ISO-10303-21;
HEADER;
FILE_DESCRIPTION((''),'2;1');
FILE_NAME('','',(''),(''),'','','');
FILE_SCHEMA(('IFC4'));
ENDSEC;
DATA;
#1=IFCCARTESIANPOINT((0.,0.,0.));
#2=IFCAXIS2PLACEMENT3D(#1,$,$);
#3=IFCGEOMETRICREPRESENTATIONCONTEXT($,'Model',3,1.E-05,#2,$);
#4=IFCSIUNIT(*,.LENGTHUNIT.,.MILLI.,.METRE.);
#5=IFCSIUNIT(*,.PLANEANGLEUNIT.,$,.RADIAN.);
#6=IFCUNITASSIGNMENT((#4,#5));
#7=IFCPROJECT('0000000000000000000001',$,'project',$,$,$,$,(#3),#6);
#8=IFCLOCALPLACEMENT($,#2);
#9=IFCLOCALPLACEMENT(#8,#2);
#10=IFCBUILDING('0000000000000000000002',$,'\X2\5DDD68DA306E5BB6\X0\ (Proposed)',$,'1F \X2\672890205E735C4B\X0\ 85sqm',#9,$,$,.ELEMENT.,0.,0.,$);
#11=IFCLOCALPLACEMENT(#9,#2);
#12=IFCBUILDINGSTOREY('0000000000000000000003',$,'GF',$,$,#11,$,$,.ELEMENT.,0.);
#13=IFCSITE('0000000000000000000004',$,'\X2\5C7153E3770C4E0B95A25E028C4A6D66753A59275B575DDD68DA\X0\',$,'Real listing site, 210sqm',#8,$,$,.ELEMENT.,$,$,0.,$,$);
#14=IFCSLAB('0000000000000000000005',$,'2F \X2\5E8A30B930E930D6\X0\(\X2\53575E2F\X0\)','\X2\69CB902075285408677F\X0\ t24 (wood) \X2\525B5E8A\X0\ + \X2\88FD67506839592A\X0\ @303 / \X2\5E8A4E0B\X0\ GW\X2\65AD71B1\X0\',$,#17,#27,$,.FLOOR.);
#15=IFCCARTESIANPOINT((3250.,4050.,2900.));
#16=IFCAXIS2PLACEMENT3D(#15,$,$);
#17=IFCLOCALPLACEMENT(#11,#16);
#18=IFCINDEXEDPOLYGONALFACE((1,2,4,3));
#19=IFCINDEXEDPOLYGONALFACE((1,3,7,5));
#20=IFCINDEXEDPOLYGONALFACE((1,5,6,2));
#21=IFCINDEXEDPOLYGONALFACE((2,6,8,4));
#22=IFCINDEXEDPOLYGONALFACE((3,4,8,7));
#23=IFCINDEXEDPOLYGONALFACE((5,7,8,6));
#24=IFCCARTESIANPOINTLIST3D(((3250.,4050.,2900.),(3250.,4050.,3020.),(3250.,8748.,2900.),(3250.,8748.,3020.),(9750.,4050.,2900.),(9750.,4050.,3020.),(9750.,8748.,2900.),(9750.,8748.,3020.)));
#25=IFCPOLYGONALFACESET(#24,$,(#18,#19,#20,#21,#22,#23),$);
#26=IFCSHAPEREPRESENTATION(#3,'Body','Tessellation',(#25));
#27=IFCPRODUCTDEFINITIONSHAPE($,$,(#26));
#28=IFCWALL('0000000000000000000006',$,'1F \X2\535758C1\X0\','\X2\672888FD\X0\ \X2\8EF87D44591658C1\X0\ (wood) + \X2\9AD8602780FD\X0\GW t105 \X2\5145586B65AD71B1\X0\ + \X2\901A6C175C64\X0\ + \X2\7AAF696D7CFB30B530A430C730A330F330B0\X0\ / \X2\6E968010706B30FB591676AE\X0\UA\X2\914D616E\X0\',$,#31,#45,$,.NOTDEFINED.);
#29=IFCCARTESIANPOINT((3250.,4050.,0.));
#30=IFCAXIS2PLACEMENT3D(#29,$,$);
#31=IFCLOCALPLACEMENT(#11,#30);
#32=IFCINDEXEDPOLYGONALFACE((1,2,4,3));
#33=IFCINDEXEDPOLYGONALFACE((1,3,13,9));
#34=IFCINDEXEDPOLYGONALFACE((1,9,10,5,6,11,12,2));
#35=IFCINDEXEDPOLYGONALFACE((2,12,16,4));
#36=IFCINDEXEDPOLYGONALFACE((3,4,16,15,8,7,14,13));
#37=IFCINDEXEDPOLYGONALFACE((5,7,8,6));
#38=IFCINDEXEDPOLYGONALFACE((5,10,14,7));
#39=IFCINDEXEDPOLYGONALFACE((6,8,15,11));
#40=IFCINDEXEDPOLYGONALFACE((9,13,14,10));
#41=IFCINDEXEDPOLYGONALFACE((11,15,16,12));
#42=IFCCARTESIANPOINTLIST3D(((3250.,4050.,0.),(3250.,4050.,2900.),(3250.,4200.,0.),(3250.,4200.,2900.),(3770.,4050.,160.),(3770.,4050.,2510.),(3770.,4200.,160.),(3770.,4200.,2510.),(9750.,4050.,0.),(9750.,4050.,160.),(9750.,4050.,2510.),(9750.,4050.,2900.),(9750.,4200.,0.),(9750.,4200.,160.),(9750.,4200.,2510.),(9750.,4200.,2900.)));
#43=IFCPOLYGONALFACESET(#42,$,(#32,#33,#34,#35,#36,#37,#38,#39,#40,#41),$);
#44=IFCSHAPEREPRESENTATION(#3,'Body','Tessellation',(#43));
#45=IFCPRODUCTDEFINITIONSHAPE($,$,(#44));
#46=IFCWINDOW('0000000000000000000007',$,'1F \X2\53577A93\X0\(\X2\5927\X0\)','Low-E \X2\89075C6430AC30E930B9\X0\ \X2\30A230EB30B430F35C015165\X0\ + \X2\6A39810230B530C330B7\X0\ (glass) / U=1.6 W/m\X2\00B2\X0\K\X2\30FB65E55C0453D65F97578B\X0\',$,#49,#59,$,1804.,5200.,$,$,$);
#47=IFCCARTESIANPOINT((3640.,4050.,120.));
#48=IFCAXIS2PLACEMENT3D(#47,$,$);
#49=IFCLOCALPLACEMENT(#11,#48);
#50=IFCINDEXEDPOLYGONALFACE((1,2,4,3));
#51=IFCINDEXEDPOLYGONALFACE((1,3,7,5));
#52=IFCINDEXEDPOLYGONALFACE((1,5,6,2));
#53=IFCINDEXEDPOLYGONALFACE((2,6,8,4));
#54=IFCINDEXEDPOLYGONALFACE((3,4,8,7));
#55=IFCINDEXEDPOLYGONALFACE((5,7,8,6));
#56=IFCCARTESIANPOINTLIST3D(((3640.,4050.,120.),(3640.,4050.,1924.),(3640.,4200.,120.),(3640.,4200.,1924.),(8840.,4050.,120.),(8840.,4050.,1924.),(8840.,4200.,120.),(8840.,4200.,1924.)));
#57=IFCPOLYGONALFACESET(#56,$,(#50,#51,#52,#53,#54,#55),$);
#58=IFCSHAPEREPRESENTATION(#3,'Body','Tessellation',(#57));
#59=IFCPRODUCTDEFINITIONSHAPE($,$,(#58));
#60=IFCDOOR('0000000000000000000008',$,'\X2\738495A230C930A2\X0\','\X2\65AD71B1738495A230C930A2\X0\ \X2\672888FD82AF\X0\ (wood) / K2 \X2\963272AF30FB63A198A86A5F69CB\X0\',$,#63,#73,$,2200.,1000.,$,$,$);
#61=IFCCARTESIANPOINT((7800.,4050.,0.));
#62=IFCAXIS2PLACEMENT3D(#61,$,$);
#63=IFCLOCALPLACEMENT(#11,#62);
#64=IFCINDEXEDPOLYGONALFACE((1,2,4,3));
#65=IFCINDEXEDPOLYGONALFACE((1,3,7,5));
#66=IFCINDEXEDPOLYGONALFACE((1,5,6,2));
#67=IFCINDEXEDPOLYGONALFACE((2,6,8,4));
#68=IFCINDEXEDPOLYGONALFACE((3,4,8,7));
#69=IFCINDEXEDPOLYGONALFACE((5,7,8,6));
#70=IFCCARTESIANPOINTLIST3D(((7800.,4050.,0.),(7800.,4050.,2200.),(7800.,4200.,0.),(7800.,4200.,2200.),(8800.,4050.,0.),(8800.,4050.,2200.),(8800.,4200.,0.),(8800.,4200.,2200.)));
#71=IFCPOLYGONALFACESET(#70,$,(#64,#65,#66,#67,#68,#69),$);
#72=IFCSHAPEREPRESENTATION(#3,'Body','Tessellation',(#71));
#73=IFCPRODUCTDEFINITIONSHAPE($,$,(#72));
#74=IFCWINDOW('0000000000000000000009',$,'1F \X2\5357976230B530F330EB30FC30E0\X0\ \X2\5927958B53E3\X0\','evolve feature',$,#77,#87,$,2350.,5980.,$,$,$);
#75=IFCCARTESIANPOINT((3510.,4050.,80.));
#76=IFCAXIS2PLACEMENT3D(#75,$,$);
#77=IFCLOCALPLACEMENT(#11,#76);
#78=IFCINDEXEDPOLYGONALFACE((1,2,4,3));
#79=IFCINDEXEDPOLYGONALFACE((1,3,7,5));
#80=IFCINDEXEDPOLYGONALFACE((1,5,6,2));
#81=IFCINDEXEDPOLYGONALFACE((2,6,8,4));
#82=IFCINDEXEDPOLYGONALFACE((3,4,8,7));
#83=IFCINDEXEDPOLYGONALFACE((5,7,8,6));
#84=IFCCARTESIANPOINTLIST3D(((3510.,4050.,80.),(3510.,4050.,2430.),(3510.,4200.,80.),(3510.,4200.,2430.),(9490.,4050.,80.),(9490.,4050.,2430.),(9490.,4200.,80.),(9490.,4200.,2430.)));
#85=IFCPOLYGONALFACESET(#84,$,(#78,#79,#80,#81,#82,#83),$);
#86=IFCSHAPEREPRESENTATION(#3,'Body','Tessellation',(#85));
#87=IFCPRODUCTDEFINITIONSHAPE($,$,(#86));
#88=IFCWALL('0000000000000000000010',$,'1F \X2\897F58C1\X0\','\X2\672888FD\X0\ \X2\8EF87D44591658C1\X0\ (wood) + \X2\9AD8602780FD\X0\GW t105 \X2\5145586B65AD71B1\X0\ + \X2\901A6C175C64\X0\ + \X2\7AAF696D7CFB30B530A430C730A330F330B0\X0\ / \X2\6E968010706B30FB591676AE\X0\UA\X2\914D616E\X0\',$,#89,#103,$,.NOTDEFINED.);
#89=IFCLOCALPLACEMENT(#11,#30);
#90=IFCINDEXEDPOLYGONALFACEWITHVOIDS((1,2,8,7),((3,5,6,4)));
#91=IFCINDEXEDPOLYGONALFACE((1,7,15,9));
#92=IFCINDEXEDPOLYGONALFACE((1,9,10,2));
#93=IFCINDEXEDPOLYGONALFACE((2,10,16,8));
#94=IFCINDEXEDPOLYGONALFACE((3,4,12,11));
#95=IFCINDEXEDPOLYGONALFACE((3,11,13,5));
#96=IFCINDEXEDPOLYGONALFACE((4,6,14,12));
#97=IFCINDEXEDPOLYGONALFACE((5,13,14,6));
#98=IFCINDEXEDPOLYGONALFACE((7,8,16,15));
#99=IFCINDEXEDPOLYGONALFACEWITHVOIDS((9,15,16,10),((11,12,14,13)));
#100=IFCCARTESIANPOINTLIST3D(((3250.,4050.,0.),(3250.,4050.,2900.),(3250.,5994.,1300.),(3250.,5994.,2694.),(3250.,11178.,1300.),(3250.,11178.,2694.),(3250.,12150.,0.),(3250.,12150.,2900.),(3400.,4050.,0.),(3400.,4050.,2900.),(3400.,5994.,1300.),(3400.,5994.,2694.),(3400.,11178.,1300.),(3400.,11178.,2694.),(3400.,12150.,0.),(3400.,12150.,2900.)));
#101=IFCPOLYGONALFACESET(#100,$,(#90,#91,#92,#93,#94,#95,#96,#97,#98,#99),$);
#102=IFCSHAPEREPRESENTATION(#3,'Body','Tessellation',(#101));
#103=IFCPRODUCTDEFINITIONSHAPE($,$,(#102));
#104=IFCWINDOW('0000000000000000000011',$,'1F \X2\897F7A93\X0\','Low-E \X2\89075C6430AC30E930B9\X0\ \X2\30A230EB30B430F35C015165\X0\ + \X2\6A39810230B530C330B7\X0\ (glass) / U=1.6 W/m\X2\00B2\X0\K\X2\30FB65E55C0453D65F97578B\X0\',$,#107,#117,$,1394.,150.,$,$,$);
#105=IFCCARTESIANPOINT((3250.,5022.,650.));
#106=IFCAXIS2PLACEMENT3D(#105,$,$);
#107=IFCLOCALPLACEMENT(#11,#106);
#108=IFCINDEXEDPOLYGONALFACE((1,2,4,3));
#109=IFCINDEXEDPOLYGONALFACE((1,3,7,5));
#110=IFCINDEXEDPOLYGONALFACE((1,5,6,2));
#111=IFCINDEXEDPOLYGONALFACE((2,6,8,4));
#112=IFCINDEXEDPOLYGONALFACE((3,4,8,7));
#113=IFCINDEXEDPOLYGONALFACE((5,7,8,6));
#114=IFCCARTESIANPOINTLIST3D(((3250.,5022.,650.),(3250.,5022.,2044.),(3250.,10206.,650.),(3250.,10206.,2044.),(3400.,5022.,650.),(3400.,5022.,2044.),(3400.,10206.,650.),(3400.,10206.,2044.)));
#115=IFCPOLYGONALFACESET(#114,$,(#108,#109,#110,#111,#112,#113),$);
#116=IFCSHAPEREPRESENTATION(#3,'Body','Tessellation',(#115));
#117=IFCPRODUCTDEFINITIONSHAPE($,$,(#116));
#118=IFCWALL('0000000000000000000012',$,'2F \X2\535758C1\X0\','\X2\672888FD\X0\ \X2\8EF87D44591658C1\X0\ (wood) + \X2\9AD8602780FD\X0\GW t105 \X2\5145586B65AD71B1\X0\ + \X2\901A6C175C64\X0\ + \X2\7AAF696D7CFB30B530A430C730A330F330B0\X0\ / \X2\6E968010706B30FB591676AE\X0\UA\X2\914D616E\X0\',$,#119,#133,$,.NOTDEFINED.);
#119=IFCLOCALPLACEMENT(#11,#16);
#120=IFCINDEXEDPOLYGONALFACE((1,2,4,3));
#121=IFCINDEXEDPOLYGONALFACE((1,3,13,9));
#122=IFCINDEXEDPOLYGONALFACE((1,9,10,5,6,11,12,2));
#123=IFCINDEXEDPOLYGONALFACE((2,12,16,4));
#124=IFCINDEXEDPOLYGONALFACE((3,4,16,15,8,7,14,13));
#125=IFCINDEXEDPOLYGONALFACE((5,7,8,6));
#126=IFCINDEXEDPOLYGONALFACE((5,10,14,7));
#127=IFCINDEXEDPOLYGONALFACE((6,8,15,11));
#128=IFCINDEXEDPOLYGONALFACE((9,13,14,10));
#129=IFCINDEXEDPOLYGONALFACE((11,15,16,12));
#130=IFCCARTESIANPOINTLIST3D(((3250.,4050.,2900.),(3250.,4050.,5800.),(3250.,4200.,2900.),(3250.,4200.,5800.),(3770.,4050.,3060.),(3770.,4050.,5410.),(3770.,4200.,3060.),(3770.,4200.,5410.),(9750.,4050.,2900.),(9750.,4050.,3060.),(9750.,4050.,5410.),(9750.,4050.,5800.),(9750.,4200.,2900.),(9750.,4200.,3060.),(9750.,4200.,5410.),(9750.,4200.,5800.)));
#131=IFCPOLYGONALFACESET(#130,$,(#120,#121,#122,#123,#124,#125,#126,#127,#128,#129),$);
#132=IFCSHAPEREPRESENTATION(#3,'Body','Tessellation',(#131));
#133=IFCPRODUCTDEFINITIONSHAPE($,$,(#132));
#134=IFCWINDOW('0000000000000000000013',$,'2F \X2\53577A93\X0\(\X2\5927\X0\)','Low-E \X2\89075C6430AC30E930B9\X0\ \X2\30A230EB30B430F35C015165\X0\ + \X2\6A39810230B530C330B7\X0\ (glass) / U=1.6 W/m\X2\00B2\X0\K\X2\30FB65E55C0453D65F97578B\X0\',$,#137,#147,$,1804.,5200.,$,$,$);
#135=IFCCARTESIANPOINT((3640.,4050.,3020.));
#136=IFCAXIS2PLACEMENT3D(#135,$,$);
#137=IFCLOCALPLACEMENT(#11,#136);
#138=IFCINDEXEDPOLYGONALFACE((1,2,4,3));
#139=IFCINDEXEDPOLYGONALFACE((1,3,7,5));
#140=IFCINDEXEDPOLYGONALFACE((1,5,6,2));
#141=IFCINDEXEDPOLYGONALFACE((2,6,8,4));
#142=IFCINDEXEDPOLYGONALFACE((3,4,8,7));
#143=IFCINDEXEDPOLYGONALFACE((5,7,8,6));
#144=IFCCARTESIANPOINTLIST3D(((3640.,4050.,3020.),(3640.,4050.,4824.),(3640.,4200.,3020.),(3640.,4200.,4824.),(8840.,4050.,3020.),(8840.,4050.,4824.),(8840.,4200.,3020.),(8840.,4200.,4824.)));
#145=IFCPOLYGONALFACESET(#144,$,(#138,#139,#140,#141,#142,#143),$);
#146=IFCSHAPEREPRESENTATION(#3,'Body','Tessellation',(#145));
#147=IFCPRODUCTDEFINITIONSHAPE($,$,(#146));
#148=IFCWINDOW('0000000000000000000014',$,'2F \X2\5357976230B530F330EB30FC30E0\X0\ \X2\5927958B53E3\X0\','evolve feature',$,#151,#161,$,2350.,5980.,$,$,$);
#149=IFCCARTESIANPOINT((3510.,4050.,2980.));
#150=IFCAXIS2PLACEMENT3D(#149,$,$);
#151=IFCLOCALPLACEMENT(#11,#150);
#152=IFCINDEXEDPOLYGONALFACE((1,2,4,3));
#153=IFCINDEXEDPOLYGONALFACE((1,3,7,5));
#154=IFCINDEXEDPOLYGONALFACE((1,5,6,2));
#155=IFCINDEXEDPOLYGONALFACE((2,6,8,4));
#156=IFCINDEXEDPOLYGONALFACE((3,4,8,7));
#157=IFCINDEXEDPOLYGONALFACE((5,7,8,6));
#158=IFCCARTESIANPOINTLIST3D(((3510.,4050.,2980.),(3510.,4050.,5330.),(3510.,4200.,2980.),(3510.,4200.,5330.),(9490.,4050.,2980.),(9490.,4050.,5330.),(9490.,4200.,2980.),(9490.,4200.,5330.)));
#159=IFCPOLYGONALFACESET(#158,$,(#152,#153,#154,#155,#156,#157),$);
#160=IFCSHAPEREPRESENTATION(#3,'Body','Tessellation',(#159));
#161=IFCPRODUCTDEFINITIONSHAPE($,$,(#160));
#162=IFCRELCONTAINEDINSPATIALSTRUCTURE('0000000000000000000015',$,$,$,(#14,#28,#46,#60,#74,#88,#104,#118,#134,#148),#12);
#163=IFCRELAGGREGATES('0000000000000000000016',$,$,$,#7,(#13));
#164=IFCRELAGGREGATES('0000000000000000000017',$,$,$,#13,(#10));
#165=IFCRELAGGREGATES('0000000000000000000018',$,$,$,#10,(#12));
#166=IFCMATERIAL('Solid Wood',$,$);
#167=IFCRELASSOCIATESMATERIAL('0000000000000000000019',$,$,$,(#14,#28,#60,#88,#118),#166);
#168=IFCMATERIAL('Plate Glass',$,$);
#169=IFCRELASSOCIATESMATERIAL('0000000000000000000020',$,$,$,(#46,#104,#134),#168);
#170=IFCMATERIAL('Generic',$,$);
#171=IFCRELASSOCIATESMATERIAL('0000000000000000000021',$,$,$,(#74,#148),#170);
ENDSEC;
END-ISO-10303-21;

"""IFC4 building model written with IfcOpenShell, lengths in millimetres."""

from ifc_helpers import new_model, si_unit, frame, frame_2d, origin, place, context, project, spatial, rectangle, extrude, material, element, fill, save


model = new_model("IFC4")

# Units and contexts
model_context = context("Model", 3, precision=1e-05, world=origin())
ifc_project = project(units=[si_unit("LENGTHUNIT", "METRE", prefix="MILLI"), si_unit("PLANEANGLEUNIT", "RADIAN")], contexts=[model_context])

# Site, building, storey
site_placement = place(None, origin())
site = spatial("IfcSite", under=ifc_project, at=site_placement, Name="山口県下関市豊浦町大字川棚", ObjectType="Real listing site, 210sqm", CompositionType="ELEMENT", RefElevation=0.0)
building_placement = place(site_placement, origin())
building = spatial("IfcBuilding", under=site, at=building_placement, Name="川棚の家 (Proposed)", ObjectType="1F 木造平屋 85sqm", CompositionType="ELEMENT", ElevationOfRefHeight=0.0, ElevationOfTerrain=0.0)
storey_placement = place(building_placement, origin())
storey = spatial("IfcBuildingStorey", under=building, at=storey_placement, Name="GF", CompositionType="ELEMENT", Elevation=0.0)

# Slab
ifc_material_1 = material(Name="Solid Wood")
slab_1_placement = place(storey_placement, frame((3250.0, 4050.0, 2900.0)))
element("IfcSlab", 1, at=slab_1_placement, inside=storey, material=ifc_material_1, Name="2F 床スラブ(南帯)", Description="構造用合板 t24 (wood) 剛床 + 製材根太 @303 / 床下 GW断熱", PredefinedType="FLOOR", context=model_context, shape_type="SweptSolid", body=[
    extrude(rectangle(XDim=6500.0, YDim=4698.0, at=frame_2d((3250.0, 2349.0))), frame((3250.0, 4050.0, 2900.0)), (0.0, 0.0, 1.0), 120.0),
])
ifc_material_2 = material(Name="Generic")

# Wall, openings, windows, door
wall_1_placement = place(storey_placement, frame((3250.0, 4050.0, 0.0)))
wall_1 = element("IfcWall", 2, at=wall_1_placement, inside=storey, material=ifc_material_1, Name="1F 南壁", Description="木製 軸組外壁 (wood) + 高性能GW t105 充填断熱 + 通気層 + 窯業系サイディング / 準耐火・外皮UA配慮", PredefinedType="NOTDEFINED", context=model_context, shape_type="SweptSolid", body=[
    extrude(rectangle(XDim=6500.0, YDim=150.0, at=frame_2d((3250.0, 75.0))), frame((3250.0, 4050.0, 0.0)), (0.0, 0.0, 1.0), 2900.0),
])
opening_1_placement = place(storey_placement, frame((3640.0, 4050.0, 120.0)))
opening_1 = element("IfcOpeningElement", 3, at=opening_1_placement, cuts=wall_1, PredefinedType="NOTDEFINED", context=model_context, shape_type="SweptSolid", body=[
    extrude(rectangle(XDim=5200.0, YDim=150.0, at=frame_2d((2600.0, 75.0))), frame((3640.0, 4050.0, 120.0)), (0.0, 0.0, 1.0), 1804.0),
])
opening_2_placement = place(storey_placement, frame((7800.0, 4050.0, 0.0)))
opening_2 = element("IfcOpeningElement", 4, at=opening_2_placement, cuts=wall_1, PredefinedType="NOTDEFINED", context=model_context, shape_type="SweptSolid", body=[
    extrude(rectangle(XDim=1000.0, YDim=150.0, at=frame_2d((500.0, 75.0))), frame((7800.0, 4050.0, 0.0)), (0.0, 0.0, 1.0), 2200.0),
])
opening_3_placement = place(storey_placement, frame((3510.0, 4050.0, 80.0)))
opening_3 = element("IfcOpeningElement", 5, at=opening_3_placement, cuts=wall_1, PredefinedType="NOTDEFINED", context=model_context, shape_type="SweptSolid", body=[
    extrude(rectangle(XDim=5980.0, YDim=150.0, at=frame_2d((2990.0, 75.0))), frame((3510.0, 4050.0, 80.0)), (0.0, 0.0, 1.0), 2350.0),
])
ifc_material_3 = material(Name="Plate Glass")
window_1_placement = place(storey_placement, frame((3640.0, 4050.0, 120.0)))
window_1 = element("IfcWindow", 6, at=window_1_placement, inside=storey, material=ifc_material_3, Name="1F 南窓(大)", Description="Low-E 複層ガラス アルゴン封入 + 樹脂サッシ (glass) / U=1.6 W/m²K・日射取得型", OverallHeight=1804.0, OverallWidth=5200.0, context=model_context, shape_type="SweptSolid", body=[
    extrude(rectangle(XDim=5200.0, YDim=150.0, at=frame_2d((2600.0, 75.0))), frame((3640.0, 4050.0, 120.0)), (0.0, 0.0, 1.0), 1804.0),
])
fill(opening_1, window_1)
door_placement = place(storey_placement, frame((7800.0, 4050.0, 0.0)))
door = element("IfcDoor", 7, at=door_placement, inside=storey, material=ifc_material_1, Name="玄関ドア", Description="断熱玄関ドア 木製芯 (wood) / K2 防犯・採風機構", OverallHeight=2200.0, OverallWidth=1000.0, context=model_context, shape_type="SweptSolid", body=[
    extrude(rectangle(XDim=1000.0, YDim=150.0, at=frame_2d((500.0, 75.0))), frame((7800.0, 4050.0, 0.0)), (0.0, 0.0, 1.0), 2200.0),
])
fill(opening_2, door)
window_2_placement = place(storey_placement, frame((3510.0, 4050.0, 80.0)))
window_2 = element("IfcWindow", 8, at=window_2_placement, inside=storey, material=ifc_material_2, Name="1F 南面サンルーム 大開口", Description="evolve feature", OverallHeight=2350.0, OverallWidth=5980.0, context=model_context, shape_type="SweptSolid", body=[
    extrude(rectangle(XDim=5980.0, YDim=150.0, at=frame_2d((2990.0, 75.0))), frame((3510.0, 4050.0, 80.0)), (0.0, 0.0, 1.0), 2350.0),
])
fill(opening_3, window_2)

# Wall, opening, window
wall_2_placement = place(storey_placement, frame((3250.0, 4050.0, 0.0)))
wall_2 = element("IfcWall", 9, at=wall_2_placement, inside=storey, material=ifc_material_1, Name="1F 西壁", Description="木製 軸組外壁 (wood) + 高性能GW t105 充填断熱 + 通気層 + 窯業系サイディング / 準耐火・外皮UA配慮", PredefinedType="NOTDEFINED", context=model_context, shape_type="SweptSolid", body=[
    extrude(rectangle(XDim=150.0, YDim=8100.0, at=frame_2d((75.0, 4050.0))), frame((3250.0, 4050.0, 0.0)), (0.0, 0.0, 1.0), 2900.0),
])
opening_4_placement = place(storey_placement, frame((3250.0, 5022.0, 650.0)))
opening_4 = element("IfcOpeningElement", 10, at=opening_4_placement, cuts=wall_2, PredefinedType="NOTDEFINED", context=model_context, shape_type="SweptSolid", body=[
    extrude(rectangle(XDim=150.0, YDim=5184.0, at=frame_2d((75.0, 2592.0))), frame((3250.0, 5022.0, 650.0)), (0.0, 0.0, 1.0), 1394.0),
])
window_3_placement = place(storey_placement, frame((3250.0, 5022.0, 650.0)))
window_3 = element("IfcWindow", 11, at=window_3_placement, inside=storey, material=ifc_material_3, Name="1F 西窓", Description="Low-E 複層ガラス アルゴン封入 + 樹脂サッシ (glass) / U=1.6 W/m²K・日射取得型", OverallHeight=1394.0, OverallWidth=150.0, context=model_context, shape_type="SweptSolid", body=[
    extrude(rectangle(XDim=150.0, YDim=5184.0, at=frame_2d((75.0, 2592.0))), frame((3250.0, 5022.0, 650.0)), (0.0, 0.0, 1.0), 1394.0),
])
fill(opening_4, window_3)

# Wall, openings, windows
wall_3_placement = place(storey_placement, frame((3250.0, 4050.0, 2900.0)))
wall_3 = element("IfcWall", 12, at=wall_3_placement, inside=storey, material=ifc_material_1, Name="2F 南壁", Description="木製 軸組外壁 (wood) + 高性能GW t105 充填断熱 + 通気層 + 窯業系サイディング / 準耐火・外皮UA配慮", PredefinedType="NOTDEFINED", context=model_context, shape_type="SweptSolid", body=[
    extrude(rectangle(XDim=6500.0, YDim=150.0, at=frame_2d((3250.0, 75.0))), frame((3250.0, 4050.0, 2900.0)), (0.0, 0.0, 1.0), 2900.0),
])
opening_5_placement = place(storey_placement, frame((3640.0, 4050.0, 3020.0)))
opening_5 = element("IfcOpeningElement", 13, at=opening_5_placement, cuts=wall_3, PredefinedType="NOTDEFINED", context=model_context, shape_type="SweptSolid", body=[
    extrude(rectangle(XDim=5200.0, YDim=150.0, at=frame_2d((2600.0, 75.0))), frame((3640.0, 4050.0, 3020.0)), (0.0, 0.0, 1.0), 1804.0),
])
opening_6_placement = place(storey_placement, frame((3510.0, 4050.0, 2980.0)))
opening_6 = element("IfcOpeningElement", 14, at=opening_6_placement, cuts=wall_3, PredefinedType="NOTDEFINED", context=model_context, shape_type="SweptSolid", body=[
    extrude(rectangle(XDim=5980.0, YDim=150.0, at=frame_2d((2990.0, 75.0))), frame((3510.0, 4050.0, 2980.0)), (0.0, 0.0, 1.0), 2350.0),
])
window_4_placement = place(storey_placement, frame((3640.0, 4050.0, 3020.0)))
window_4 = element("IfcWindow", 15, at=window_4_placement, inside=storey, material=ifc_material_3, Name="2F 南窓(大)", Description="Low-E 複層ガラス アルゴン封入 + 樹脂サッシ (glass) / U=1.6 W/m²K・日射取得型", OverallHeight=1804.0, OverallWidth=5200.0, context=model_context, shape_type="SweptSolid", body=[
    extrude(rectangle(XDim=5200.0, YDim=150.0, at=frame_2d((2600.0, 75.0))), frame((3640.0, 4050.0, 3020.0)), (0.0, 0.0, 1.0), 1804.0),
])
fill(opening_5, window_4)
window_5_placement = place(storey_placement, frame((3510.0, 4050.0, 2980.0)))
window_5 = element("IfcWindow", 16, at=window_5_placement, inside=storey, material=ifc_material_2, Name="2F 南面サンルーム 大開口", Description="evolve feature", OverallHeight=2350.0, OverallWidth=5980.0, context=model_context, shape_type="SweptSolid", body=[
    extrude(rectangle(XDim=5980.0, YDim=150.0, at=frame_2d((2990.0, 75.0))), frame((3510.0, 4050.0, 2980.0)), (0.0, 0.0, 1.0), 2350.0),
])
fill(opening_6, window_5)

save(model, "model.ifc")
